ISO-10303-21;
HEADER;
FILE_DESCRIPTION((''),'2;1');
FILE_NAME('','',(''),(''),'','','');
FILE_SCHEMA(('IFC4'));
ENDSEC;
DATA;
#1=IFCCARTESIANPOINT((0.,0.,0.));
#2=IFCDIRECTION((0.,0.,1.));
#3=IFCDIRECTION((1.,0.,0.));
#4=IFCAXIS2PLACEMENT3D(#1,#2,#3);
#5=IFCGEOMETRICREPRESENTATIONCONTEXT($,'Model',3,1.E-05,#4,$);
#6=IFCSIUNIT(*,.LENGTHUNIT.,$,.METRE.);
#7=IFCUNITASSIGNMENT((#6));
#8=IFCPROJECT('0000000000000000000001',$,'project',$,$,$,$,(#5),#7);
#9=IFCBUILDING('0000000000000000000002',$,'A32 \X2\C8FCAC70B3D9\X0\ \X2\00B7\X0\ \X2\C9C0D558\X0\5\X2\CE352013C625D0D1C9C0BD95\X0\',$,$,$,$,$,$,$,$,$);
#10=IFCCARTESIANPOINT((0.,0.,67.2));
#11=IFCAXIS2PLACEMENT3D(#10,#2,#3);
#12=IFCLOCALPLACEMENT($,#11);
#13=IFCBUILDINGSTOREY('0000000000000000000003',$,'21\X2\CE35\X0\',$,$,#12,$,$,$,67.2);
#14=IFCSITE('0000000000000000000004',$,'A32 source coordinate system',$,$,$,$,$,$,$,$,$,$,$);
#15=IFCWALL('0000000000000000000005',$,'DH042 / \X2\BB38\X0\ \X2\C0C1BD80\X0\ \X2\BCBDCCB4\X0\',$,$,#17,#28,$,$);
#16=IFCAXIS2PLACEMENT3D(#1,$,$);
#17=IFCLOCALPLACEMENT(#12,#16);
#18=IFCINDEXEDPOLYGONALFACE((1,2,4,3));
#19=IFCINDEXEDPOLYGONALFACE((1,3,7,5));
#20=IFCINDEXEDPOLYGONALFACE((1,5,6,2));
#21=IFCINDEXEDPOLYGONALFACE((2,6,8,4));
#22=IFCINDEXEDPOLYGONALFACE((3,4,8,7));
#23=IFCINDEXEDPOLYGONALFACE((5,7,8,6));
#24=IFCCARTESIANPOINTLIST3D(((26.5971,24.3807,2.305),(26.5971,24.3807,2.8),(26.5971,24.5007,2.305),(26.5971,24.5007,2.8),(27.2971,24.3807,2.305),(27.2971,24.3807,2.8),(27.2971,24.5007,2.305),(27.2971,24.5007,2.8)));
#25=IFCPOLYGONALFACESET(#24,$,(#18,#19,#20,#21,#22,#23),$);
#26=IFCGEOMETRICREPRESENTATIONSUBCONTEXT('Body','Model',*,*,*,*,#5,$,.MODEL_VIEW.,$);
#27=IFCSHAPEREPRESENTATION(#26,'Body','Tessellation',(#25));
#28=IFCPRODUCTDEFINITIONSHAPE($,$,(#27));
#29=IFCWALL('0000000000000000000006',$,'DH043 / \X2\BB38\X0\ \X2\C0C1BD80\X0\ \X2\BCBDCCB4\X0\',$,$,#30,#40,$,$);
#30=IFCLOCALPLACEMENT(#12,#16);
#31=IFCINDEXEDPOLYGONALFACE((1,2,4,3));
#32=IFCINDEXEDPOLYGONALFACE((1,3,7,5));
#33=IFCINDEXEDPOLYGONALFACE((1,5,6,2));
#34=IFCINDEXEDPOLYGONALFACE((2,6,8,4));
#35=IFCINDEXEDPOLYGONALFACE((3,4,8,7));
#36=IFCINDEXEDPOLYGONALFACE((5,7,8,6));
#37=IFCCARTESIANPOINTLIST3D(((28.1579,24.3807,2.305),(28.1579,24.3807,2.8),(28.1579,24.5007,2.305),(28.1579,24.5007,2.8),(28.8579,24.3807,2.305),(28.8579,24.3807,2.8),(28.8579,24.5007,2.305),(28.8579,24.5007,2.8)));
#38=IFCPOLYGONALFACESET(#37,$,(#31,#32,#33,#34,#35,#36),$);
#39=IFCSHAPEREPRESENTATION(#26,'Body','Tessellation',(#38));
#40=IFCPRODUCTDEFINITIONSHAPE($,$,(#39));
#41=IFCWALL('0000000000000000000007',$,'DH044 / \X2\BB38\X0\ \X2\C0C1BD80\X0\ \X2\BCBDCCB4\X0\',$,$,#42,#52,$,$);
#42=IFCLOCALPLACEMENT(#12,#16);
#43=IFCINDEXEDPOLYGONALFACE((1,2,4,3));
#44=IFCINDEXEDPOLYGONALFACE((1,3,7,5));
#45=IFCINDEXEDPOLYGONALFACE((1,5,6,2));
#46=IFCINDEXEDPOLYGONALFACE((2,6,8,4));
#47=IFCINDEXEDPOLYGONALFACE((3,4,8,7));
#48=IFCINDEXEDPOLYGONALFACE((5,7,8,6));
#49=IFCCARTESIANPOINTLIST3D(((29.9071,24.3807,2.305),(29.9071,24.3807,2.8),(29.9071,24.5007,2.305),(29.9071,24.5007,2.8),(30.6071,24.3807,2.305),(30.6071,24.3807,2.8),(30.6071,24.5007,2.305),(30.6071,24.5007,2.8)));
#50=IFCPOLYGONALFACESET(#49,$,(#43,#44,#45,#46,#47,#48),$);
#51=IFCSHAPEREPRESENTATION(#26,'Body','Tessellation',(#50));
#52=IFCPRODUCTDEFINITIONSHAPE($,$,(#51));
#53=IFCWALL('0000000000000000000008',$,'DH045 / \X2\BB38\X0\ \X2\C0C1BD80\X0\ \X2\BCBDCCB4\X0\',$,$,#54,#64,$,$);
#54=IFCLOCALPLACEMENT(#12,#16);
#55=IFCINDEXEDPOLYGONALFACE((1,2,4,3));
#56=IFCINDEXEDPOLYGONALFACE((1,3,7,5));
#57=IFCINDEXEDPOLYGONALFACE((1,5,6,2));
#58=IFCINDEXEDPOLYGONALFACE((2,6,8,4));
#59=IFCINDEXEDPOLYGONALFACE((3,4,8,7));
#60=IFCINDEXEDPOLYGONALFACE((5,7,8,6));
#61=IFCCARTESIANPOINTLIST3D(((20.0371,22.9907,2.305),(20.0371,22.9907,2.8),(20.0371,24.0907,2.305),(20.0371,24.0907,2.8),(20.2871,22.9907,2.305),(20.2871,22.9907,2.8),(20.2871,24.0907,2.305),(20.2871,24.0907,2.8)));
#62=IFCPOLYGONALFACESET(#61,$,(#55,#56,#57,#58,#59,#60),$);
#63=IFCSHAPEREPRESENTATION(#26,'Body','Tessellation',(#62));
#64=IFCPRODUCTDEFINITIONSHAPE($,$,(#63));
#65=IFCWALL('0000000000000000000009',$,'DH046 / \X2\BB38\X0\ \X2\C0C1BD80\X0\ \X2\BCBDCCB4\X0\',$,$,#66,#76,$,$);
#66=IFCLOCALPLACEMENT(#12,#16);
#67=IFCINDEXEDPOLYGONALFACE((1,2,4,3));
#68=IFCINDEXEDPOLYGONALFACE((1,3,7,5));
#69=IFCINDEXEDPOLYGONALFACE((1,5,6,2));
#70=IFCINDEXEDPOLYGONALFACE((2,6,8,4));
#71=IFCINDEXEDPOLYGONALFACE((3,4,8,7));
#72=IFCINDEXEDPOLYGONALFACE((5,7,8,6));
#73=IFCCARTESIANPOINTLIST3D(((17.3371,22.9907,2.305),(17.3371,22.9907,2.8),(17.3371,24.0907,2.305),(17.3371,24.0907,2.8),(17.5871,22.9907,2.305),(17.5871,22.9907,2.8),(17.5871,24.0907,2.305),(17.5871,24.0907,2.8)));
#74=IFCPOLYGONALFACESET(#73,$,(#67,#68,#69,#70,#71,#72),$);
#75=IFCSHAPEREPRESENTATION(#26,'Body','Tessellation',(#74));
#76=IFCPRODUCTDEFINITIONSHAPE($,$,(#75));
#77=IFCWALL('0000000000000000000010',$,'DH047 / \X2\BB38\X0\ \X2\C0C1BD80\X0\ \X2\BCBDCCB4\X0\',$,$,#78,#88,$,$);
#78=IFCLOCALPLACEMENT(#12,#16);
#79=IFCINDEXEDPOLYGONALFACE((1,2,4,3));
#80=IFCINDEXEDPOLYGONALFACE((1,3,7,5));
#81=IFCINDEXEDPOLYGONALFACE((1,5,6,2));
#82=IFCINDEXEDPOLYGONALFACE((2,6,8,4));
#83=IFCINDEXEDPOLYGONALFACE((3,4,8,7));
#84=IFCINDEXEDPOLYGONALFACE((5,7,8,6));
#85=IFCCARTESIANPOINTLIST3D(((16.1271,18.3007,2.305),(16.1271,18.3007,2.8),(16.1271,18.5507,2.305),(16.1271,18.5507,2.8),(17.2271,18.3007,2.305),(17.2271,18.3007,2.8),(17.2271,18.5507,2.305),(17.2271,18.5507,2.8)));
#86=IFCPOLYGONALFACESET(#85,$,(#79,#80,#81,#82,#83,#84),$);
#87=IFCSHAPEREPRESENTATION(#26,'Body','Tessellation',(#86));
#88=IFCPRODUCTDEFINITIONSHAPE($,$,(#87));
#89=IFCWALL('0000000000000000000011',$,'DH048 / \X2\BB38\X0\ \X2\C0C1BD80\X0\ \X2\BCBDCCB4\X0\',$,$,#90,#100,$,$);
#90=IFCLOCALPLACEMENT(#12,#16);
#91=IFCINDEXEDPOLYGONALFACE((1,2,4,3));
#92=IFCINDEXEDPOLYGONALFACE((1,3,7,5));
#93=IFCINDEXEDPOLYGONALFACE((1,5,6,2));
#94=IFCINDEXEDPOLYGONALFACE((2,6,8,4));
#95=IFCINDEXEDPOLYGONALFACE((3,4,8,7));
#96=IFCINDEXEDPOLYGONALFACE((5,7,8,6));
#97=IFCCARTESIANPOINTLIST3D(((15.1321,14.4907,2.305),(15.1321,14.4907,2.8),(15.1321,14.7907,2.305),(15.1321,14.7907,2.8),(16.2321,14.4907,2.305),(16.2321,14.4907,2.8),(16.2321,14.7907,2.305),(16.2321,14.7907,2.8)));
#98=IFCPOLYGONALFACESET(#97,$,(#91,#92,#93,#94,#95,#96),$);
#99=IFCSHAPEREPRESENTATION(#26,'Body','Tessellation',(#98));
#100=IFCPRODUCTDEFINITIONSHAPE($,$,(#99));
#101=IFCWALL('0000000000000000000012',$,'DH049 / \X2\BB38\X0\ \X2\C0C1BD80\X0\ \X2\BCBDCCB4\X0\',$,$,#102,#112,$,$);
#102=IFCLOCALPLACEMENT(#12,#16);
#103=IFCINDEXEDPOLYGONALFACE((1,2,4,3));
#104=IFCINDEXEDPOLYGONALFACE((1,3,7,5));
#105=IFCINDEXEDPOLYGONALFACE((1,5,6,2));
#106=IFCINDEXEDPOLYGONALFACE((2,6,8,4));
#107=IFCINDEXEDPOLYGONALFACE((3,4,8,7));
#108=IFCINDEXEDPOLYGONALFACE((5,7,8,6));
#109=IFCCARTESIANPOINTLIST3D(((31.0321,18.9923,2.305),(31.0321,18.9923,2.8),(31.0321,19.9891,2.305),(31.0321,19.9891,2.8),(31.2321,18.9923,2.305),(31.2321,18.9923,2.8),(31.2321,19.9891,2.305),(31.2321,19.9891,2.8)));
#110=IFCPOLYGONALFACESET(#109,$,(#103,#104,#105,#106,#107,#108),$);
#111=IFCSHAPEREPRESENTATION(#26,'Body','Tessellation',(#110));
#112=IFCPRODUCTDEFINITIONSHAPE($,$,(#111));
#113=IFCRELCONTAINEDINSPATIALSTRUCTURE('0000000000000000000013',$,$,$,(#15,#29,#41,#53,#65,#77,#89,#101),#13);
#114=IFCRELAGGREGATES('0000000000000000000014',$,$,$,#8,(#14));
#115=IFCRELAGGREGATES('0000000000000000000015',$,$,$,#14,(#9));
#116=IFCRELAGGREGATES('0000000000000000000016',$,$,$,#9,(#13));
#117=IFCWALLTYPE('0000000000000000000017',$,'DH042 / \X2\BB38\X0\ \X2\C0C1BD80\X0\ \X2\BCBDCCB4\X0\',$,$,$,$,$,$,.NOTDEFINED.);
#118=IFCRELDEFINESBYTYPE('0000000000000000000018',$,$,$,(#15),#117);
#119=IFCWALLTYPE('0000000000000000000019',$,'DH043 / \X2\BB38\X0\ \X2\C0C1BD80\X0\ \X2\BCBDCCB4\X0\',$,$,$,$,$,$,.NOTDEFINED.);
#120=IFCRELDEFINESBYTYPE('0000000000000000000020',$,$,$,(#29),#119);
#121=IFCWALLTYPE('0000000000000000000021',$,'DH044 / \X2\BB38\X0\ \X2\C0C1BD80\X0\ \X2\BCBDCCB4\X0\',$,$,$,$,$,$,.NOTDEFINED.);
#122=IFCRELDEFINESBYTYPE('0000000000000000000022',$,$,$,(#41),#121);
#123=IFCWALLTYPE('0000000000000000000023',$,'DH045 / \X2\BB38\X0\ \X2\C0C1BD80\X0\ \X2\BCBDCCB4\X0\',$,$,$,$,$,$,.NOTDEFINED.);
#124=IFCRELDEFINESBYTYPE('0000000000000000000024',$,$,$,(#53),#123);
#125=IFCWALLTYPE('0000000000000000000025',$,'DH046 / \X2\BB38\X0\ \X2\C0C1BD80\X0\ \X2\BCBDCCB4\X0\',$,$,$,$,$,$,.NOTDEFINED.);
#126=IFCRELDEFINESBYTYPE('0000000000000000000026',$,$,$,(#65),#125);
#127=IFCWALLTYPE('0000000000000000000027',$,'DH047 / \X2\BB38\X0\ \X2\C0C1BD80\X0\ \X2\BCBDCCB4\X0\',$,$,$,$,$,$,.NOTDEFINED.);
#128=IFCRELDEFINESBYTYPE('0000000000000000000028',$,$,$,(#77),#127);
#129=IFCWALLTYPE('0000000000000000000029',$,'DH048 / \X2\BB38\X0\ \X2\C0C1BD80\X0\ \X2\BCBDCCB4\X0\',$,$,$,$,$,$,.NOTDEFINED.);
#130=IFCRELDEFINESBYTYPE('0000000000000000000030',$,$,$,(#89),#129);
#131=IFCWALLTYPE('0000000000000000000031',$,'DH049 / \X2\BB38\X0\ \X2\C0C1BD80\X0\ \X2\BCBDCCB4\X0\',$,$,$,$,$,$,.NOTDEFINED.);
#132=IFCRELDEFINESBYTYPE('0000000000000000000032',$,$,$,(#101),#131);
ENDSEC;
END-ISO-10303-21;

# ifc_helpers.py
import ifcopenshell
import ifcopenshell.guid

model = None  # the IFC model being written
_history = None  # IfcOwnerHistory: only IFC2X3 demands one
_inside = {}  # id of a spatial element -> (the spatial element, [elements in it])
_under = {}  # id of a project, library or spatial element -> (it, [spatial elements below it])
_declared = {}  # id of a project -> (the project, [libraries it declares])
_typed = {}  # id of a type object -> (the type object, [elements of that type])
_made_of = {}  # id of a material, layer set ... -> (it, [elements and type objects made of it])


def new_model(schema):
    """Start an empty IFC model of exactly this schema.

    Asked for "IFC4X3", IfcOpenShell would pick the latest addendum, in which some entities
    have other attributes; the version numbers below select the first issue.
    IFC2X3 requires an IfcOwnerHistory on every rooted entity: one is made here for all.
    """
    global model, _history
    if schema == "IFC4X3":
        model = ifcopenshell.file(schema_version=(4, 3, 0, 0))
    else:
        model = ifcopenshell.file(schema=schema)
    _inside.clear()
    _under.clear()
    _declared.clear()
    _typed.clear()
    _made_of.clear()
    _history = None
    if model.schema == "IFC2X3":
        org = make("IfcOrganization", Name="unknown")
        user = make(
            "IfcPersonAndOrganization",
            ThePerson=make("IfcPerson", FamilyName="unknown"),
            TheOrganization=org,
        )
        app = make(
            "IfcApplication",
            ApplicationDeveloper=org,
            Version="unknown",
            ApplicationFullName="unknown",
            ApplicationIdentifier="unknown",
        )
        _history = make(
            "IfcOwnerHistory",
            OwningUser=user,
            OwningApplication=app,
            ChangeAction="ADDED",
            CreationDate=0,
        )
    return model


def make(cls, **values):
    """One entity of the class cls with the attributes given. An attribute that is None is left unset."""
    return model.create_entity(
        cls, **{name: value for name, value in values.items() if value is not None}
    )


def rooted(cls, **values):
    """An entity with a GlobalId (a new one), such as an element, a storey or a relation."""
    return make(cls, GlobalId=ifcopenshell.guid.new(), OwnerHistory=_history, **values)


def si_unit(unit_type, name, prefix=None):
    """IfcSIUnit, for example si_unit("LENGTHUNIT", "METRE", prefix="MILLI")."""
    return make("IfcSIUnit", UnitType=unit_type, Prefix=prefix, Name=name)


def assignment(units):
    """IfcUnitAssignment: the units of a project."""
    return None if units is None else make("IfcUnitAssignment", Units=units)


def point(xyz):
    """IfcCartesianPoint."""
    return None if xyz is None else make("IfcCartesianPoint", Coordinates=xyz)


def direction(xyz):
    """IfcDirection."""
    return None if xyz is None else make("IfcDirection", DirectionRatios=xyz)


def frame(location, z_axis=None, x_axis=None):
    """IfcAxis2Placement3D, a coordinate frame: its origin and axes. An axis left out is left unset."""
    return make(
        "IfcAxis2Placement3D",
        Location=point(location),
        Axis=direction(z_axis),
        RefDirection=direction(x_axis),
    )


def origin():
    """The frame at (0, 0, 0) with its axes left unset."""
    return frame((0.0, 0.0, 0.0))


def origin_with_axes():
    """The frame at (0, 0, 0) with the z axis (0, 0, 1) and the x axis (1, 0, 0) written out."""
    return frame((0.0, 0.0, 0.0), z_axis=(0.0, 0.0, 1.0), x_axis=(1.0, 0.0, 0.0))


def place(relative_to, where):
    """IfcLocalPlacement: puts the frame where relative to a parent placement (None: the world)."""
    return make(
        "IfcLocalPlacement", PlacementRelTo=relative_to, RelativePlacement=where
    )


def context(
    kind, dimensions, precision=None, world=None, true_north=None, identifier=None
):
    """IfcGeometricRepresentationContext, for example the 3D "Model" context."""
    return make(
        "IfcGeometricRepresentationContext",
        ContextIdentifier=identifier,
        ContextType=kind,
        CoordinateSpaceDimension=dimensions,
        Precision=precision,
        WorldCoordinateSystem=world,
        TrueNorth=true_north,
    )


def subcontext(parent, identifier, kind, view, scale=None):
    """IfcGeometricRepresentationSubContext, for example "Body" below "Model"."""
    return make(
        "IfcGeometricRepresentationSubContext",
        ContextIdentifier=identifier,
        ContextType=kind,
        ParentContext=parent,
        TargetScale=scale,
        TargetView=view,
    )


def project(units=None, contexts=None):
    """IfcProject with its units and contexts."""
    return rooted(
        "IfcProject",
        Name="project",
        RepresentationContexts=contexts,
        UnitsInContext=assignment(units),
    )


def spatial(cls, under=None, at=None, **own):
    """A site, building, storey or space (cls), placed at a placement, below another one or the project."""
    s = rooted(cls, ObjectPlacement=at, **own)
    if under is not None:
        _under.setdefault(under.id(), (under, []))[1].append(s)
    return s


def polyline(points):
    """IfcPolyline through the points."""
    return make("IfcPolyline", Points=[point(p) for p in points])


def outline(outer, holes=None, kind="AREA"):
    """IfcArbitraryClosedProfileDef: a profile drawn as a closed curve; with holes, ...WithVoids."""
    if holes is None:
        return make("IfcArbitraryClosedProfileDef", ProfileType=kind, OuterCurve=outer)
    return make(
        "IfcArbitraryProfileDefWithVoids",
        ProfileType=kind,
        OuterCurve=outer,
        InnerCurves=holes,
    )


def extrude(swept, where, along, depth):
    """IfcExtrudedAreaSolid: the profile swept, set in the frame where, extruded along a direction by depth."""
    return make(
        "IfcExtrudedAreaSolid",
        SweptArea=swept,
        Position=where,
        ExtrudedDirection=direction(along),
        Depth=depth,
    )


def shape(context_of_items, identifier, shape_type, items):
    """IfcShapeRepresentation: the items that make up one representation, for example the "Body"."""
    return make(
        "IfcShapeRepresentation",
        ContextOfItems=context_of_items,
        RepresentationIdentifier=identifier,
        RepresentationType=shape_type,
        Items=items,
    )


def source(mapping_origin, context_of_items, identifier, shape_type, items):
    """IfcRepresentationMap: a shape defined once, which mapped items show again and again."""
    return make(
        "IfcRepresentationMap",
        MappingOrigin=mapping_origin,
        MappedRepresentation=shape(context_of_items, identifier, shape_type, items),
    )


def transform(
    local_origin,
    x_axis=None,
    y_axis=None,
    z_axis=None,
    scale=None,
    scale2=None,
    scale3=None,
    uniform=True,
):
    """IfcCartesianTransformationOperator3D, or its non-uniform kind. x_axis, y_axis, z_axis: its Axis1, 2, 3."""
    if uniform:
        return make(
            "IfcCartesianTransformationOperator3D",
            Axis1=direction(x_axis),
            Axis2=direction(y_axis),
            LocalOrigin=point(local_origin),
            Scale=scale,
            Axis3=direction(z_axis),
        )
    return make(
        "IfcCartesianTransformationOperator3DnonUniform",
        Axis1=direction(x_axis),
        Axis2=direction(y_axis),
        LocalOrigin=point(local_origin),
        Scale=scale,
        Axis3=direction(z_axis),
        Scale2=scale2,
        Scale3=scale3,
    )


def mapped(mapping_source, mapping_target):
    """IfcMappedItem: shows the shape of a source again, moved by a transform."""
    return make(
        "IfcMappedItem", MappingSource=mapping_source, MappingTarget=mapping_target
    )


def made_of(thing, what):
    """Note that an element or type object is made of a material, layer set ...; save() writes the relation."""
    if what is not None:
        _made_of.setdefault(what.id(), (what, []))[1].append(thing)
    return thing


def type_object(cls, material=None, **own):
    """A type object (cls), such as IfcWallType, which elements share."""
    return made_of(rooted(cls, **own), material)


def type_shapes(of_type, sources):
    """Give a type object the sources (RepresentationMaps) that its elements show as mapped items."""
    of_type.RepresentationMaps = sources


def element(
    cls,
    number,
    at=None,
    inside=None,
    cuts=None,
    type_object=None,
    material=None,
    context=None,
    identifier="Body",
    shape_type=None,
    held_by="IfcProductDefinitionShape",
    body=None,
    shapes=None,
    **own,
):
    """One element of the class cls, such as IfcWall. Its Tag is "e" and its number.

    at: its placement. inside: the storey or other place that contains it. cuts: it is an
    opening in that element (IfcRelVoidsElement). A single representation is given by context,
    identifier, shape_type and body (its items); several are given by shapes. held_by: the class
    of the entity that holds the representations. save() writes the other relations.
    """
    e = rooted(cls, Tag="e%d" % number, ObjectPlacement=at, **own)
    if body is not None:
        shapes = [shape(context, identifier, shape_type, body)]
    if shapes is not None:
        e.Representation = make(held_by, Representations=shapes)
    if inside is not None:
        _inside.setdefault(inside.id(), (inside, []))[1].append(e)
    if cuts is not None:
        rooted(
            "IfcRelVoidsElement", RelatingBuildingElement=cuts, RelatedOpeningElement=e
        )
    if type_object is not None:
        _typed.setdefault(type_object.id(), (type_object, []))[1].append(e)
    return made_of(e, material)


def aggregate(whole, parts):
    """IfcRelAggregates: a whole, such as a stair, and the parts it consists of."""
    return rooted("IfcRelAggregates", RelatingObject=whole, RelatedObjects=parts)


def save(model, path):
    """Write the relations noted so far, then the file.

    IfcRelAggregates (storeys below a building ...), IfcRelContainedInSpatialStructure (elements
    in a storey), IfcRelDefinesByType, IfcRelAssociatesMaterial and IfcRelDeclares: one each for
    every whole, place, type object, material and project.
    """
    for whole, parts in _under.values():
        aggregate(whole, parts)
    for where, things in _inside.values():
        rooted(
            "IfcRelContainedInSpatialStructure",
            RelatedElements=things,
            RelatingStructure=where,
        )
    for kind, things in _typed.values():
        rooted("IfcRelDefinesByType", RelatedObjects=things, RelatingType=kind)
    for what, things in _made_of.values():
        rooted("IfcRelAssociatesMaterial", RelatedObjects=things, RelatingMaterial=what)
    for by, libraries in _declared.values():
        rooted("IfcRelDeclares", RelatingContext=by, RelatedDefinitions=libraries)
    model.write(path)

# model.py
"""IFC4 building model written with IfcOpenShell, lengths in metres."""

from ifc_helpers import new_model, si_unit, frame, origin, origin_with_axes, place, context, subcontext, project, spatial, polyline, outline, extrude, source, transform, mapped, type_object, type_shapes, element, save


model = new_model("IFC4")

# Units and contexts
model_context = context("Model", 3, precision=1e-05, world=origin_with_axes())
body_context = subcontext(model_context, "Body", "Model", "MODEL_VIEW")
ifc_project = project(units=[si_unit("LENGTHUNIT", "METRE")], contexts=[model_context])

# Site, building, storey
site = spatial("IfcSite", under=ifc_project, Name="A32 source coordinate system")
building = spatial("IfcBuilding", under=site, Name="A32 주거동 · 지하5층–옥탑지붕")
storey_placement = place(None, frame((0.0, 0.0, 67.2), z_axis=(0.0, 0.0, 1.0), x_axis=(1.0, 0.0, 0.0)))
storey = spatial("IfcBuildingStorey", under=building, at=storey_placement, Name="21층", Elevation=67.2)

# Walls
wall_type_1 = type_object("IfcWallType", Name="DH042 / 문 상부 벽체", PredefinedType="NOTDEFINED")
shared_shape_1 = source(origin(), body_context, "Body", "SweptSolid", [
    extrude(outline(polyline([(27.2971, 24.3807), (26.5971, 24.3807), (26.5971, 24.5007), (27.2971, 24.5007), (27.2971, 24.3807)])), frame((0.0, 0.0, 2.305)), (0.0, 0.0, 1.0), 0.495),
])
type_shapes(wall_type_1, [shared_shape_1])
wall_1_placement = place(storey_placement, origin_with_axes())
element("IfcWall", 1, at=wall_1_placement, inside=storey, type_object=wall_type_1, Name="DH042 / 문 상부 벽체", context=body_context, shape_type="MappedRepresentation", body=[
    mapped(shared_shape_1, transform((0.0, 0.0, 0.0), scale=1.0)),
])
wall_type_2 = type_object("IfcWallType", Name="DH043 / 문 상부 벽체", PredefinedType="NOTDEFINED")
shared_shape_2 = source(origin(), body_context, "Body", "SweptSolid", [
    extrude(outline(polyline([(28.8579, 24.3807), (28.1579, 24.3807), (28.1579, 24.5007), (28.8579, 24.5007), (28.8579, 24.3807)])), frame((0.0, 0.0, 2.305)), (0.0, 0.0, 1.0), 0.495),
])
type_shapes(wall_type_2, [shared_shape_2])
wall_2_placement = place(storey_placement, origin_with_axes())
element("IfcWall", 2, at=wall_2_placement, inside=storey, type_object=wall_type_2, Name="DH043 / 문 상부 벽체", context=body_context, shape_type="MappedRepresentation", body=[
    mapped(shared_shape_2, transform((0.0, 0.0, 0.0), scale=1.0)),
])
wall_type_3 = type_object("IfcWallType", Name="DH044 / 문 상부 벽체", PredefinedType="NOTDEFINED")
shared_shape_3 = source(origin(), body_context, "Body", "SweptSolid", [
    extrude(outline(polyline([(30.6071, 24.3807), (29.9071, 24.3807), (29.9071, 24.5007), (30.6071, 24.5007), (30.6071, 24.3807)])), frame((0.0, 0.0, 2.305)), (0.0, 0.0, 1.0), 0.495),
])
type_shapes(wall_type_3, [shared_shape_3])
wall_3_placement = place(storey_placement, origin_with_axes())
element("IfcWall", 3, at=wall_3_placement, inside=storey, type_object=wall_type_3, Name="DH044 / 문 상부 벽체", context=body_context, shape_type="MappedRepresentation", body=[
    mapped(shared_shape_3, transform((0.0, 0.0, 0.0), scale=1.0)),
])
wall_type_4 = type_object("IfcWallType", Name="DH045 / 문 상부 벽체", PredefinedType="NOTDEFINED")
shared_shape_4 = source(origin(), body_context, "Body", "SweptSolid", [
    extrude(outline(polyline([(20.2871, 22.9907), (20.0371, 22.9907), (20.0371, 24.0907), (20.2871, 24.0907), (20.2871, 22.9907)])), frame((0.0, 0.0, 2.305)), (0.0, 0.0, 1.0), 0.495),
])
type_shapes(wall_type_4, [shared_shape_4])
wall_4_placement = place(storey_placement, origin_with_axes())
element("IfcWall", 4, at=wall_4_placement, inside=storey, type_object=wall_type_4, Name="DH045 / 문 상부 벽체", context=body_context, shape_type="MappedRepresentation", body=[
    mapped(shared_shape_4, transform((0.0, 0.0, 0.0), scale=1.0)),
])
wall_type_5 = type_object("IfcWallType", Name="DH046 / 문 상부 벽체", PredefinedType="NOTDEFINED")
shared_shape_5 = source(origin(), body_context, "Body", "SweptSolid", [
    extrude(outline(polyline([(17.5871, 22.9907), (17.3371, 22.9907), (17.3371, 24.0907), (17.5871, 24.0907), (17.5871, 22.9907)])), frame((0.0, 0.0, 2.305)), (0.0, 0.0, 1.0), 0.495),
])
type_shapes(wall_type_5, [shared_shape_5])
wall_5_placement = place(storey_placement, origin_with_axes())
element("IfcWall", 5, at=wall_5_placement, inside=storey, type_object=wall_type_5, Name="DH046 / 문 상부 벽체", context=body_context, shape_type="MappedRepresentation", body=[
    mapped(shared_shape_5, transform((0.0, 0.0, 0.0), scale=1.0)),
])
wall_type_6 = type_object("IfcWallType", Name="DH047 / 문 상부 벽체", PredefinedType="NOTDEFINED")
shared_shape_6 = source(origin(), body_context, "Body", "SweptSolid", [
    extrude(outline(polyline([(17.2271, 18.3007), (16.1271, 18.3007), (16.1271, 18.5507), (17.2271, 18.5507), (17.2271, 18.3007)])), frame((0.0, 0.0, 2.305)), (0.0, 0.0, 1.0), 0.495),
])
type_shapes(wall_type_6, [shared_shape_6])
wall_6_placement = place(storey_placement, origin_with_axes())
element("IfcWall", 6, at=wall_6_placement, inside=storey, type_object=wall_type_6, Name="DH047 / 문 상부 벽체", context=body_context, shape_type="MappedRepresentation", body=[
    mapped(shared_shape_6, transform((0.0, 0.0, 0.0), scale=1.0)),
])
wall_type_7 = type_object("IfcWallType", Name="DH048 / 문 상부 벽체", PredefinedType="NOTDEFINED")
shared_shape_7 = source(origin(), body_context, "Body", "SweptSolid", [
    extrude(outline(polyline([(15.1321, 14.7907), (16.2321, 14.7907), (16.2321, 14.4907), (15.1321, 14.4907), (15.1321, 14.7907)])), frame((0.0, 0.0, 2.305)), (0.0, 0.0, 1.0), 0.495),
])
type_shapes(wall_type_7, [shared_shape_7])
wall_7_placement = place(storey_placement, origin_with_axes())
element("IfcWall", 7, at=wall_7_placement, inside=storey, type_object=wall_type_7, Name="DH048 / 문 상부 벽체", context=body_context, shape_type="MappedRepresentation", body=[
    mapped(shared_shape_7, transform((0.0, 0.0, 0.0), scale=1.0)),
])
wall_type_8 = type_object("IfcWallType", Name="DH049 / 문 상부 벽체", PredefinedType="NOTDEFINED")
shared_shape_8 = source(origin(), body_context, "Body", "SweptSolid", [
    extrude(outline(polyline([(31.2321, 18.9923), (31.0321, 18.9923), (31.0321, 19.9891), (31.2321, 19.9891), (31.2321, 18.9923)])), frame((0.0, 0.0, 2.305)), (0.0, 0.0, 1.0), 0.495),
])
type_shapes(wall_type_8, [shared_shape_8])
wall_8_placement = place(storey_placement, origin_with_axes())
element("IfcWall", 8, at=wall_8_placement, inside=storey, type_object=wall_type_8, Name="DH049 / 문 상부 벽체", context=body_context, shape_type="MappedRepresentation", body=[
    mapped(shared_shape_8, transform((0.0, 0.0, 0.0), scale=1.0)),
])

save(model, "model.ifc")
